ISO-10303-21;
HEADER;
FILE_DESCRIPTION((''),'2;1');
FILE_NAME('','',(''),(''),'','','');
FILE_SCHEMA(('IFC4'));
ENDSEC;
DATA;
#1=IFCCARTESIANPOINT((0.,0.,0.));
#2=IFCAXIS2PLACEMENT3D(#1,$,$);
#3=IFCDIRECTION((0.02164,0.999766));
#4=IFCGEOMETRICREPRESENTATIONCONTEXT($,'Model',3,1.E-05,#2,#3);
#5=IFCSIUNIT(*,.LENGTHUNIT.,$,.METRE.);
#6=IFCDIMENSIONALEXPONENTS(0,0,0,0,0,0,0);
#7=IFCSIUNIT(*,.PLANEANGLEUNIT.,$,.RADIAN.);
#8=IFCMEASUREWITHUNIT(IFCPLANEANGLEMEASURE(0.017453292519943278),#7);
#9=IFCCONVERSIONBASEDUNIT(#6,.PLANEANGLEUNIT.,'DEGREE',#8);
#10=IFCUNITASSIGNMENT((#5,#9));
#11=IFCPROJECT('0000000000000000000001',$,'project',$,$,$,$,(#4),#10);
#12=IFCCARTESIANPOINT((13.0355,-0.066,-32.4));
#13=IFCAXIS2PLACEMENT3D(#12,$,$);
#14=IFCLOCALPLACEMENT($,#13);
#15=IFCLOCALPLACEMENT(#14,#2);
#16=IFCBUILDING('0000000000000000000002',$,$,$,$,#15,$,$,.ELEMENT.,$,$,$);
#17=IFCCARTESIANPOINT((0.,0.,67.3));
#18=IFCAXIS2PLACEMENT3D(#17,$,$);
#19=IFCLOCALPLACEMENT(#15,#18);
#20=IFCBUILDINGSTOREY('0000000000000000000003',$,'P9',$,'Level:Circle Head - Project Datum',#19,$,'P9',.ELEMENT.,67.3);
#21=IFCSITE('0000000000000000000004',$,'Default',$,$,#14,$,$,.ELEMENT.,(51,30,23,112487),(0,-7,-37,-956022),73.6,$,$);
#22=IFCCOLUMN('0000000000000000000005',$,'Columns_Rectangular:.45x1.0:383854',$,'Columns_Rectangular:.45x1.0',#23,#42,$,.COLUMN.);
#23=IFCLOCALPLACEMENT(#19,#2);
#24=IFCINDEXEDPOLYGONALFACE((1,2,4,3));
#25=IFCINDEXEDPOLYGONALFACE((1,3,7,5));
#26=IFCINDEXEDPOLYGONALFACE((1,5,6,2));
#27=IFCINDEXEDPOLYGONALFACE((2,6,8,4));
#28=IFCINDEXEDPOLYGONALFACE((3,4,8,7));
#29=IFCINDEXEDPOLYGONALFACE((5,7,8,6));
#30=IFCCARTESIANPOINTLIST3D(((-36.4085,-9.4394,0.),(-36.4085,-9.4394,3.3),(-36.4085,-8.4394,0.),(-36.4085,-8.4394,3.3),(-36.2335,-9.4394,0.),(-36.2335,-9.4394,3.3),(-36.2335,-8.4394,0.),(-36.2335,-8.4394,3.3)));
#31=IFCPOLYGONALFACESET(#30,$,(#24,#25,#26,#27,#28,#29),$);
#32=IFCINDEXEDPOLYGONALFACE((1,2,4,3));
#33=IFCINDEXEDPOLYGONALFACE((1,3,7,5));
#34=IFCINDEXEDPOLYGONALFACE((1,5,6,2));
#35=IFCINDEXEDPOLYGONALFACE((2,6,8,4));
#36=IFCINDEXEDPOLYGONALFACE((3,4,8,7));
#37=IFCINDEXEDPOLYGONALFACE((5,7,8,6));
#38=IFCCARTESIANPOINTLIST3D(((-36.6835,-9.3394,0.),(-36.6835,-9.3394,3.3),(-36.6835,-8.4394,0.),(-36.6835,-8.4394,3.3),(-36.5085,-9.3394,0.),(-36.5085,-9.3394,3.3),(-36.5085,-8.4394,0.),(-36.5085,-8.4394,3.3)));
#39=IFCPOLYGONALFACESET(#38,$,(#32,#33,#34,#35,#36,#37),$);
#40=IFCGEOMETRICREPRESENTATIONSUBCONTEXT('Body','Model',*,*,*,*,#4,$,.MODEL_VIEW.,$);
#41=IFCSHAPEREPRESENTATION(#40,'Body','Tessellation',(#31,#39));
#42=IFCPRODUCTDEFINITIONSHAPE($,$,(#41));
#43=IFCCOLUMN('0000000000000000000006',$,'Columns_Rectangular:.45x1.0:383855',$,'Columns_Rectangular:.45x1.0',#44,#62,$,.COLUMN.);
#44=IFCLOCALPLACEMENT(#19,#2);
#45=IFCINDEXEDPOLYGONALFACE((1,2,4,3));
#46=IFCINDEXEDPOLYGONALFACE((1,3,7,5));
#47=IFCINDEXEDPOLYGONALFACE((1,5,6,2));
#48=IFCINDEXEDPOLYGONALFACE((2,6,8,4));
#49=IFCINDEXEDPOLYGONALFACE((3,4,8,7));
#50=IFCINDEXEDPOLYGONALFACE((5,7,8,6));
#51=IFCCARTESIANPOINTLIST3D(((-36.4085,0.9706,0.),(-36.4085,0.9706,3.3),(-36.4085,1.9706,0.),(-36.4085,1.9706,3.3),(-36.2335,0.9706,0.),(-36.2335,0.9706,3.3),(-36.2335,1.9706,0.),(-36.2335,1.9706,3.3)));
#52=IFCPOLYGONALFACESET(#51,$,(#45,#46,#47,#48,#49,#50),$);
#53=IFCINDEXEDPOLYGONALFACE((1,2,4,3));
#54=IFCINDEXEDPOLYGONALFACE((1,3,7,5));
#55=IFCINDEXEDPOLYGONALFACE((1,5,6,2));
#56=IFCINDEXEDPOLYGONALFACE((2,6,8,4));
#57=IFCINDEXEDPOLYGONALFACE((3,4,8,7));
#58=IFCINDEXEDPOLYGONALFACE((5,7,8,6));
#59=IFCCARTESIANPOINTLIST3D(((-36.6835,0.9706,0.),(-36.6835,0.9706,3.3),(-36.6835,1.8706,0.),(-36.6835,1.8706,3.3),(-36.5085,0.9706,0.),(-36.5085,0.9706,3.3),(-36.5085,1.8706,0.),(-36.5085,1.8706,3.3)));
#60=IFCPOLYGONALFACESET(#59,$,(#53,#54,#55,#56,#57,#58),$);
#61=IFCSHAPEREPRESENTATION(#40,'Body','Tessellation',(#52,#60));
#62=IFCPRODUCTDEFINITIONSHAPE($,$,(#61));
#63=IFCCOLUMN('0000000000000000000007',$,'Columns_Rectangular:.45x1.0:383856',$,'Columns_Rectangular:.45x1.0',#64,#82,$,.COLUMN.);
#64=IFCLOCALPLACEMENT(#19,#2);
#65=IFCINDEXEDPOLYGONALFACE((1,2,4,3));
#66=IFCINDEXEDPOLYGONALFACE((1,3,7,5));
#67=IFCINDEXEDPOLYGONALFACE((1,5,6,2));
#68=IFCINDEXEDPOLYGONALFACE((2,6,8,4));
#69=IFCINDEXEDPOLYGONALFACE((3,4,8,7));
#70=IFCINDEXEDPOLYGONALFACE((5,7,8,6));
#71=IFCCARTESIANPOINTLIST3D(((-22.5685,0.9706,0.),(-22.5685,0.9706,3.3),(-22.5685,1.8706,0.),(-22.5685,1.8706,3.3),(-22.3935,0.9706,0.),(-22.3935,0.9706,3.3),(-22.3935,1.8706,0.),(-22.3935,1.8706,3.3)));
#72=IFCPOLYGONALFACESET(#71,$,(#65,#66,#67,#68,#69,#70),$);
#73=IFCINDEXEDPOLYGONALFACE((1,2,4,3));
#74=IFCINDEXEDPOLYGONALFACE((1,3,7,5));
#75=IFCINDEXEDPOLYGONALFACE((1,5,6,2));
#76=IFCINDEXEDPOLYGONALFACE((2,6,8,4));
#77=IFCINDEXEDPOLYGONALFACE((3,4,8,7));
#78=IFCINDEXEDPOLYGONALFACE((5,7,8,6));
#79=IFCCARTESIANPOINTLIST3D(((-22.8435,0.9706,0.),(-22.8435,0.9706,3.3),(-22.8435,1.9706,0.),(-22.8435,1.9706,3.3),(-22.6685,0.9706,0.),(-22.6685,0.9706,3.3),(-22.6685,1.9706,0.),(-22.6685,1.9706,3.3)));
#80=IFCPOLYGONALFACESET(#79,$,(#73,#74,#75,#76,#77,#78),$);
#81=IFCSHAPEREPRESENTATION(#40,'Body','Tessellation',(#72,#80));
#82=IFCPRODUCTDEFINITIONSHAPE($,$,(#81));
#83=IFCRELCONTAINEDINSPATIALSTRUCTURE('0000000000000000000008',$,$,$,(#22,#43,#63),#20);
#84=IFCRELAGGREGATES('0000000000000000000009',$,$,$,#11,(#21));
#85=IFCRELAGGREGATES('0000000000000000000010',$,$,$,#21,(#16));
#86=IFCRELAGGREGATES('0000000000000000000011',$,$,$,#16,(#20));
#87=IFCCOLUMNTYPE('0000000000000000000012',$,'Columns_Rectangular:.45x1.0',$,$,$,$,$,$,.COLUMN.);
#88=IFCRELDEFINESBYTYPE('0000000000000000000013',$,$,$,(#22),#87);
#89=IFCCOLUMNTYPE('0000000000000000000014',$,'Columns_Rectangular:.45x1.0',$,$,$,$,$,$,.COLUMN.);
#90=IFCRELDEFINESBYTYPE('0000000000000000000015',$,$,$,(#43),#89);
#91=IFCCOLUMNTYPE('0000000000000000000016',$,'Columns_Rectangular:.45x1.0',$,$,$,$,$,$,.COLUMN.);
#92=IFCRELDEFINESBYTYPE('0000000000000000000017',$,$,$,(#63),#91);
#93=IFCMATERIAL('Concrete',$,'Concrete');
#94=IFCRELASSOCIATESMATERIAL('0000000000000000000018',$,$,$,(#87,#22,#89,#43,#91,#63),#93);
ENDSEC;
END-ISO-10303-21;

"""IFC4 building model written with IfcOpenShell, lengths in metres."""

from ifc_helpers import new_model, entity, si_unit, converted_unit, direction, frame, origin, place, context, subcontext, project, spatial, indexed_curve, outline, extrude, source, transform, mapped, material, type_object, type_shapes, element, save


model = new_model("IFC4")

# Units and contexts
model_context = context("Model", 3, precision=1e-05, world=origin(), true_north=direction((0.02164, 0.999766)))
body_context = subcontext(model_context, "Body", "Model", "MODEL_VIEW")
ifc_project = project(units=[si_unit("LENGTHUNIT", "METRE"), converted_unit("PLANEANGLEUNIT", "DEGREE", entity("IfcPlaneAngleMeasure", 0.017453292519943278), si_unit("PLANEANGLEUNIT", "RADIAN"), dimensions=[0, 0, 0, 0, 0, 0, 0])], contexts=[model_context])

# Site, building, storey
site_placement = place(None, frame((13.0355, -0.066, -32.4)))
site = spatial("IfcSite", under=ifc_project, at=site_placement, Name="Default", CompositionType="ELEMENT", RefLatitude=(51, 30, 23, 112487), RefLongitude=(0, -7, -37, -956022), RefElevation=73.6)
building_placement = place(site_placement, origin())
building = spatial("IfcBuilding", under=site, at=building_placement, CompositionType="ELEMENT")
storey_placement = place(building_placement, frame((0.0, 0.0, 67.3)))
storey = spatial("IfcBuildingStorey", under=building, at=storey_placement, Name="P9", ObjectType="Level:Circle Head - Project Datum", LongName="P9", CompositionType="ELEMENT", Elevation=67.3)

# Columns
ifc_material = material(Name="Concrete", Category="Concrete")
column_type_1 = type_object("IfcColumnType", Name="Columns_Rectangular:.45x1.0", PredefinedType="COLUMN", material=ifc_material)
shared_shape_1 = source(origin(), body_context, "Body", "SweptSolid", [
    extrude(outline(indexed_curve([(-0.0875, -0.5), (0.0875, -0.5), (0.0875, 0.5), (-0.0875, 0.5), (-0.0875, -0.5)], self_intersect=False)), frame((-36.321, -8.9394, 67.3), z_axis=(0.0, 0.0, 1.0), x_axis=(-1.0, 0.0, 0.0)), (0.0, 0.0, 1.0), 3.3),
    extrude(outline(indexed_curve([(-0.45, -0.0875), (0.45, -0.0875), (0.45, 0.0875), (-0.45, 0.0875), (-0.45, -0.0875)], self_intersect=False)), frame((-36.596, -8.8894, 67.3), z_axis=(0.0, 0.0, 1.0), x_axis=(0.0, -1.0, 0.0)), (0.0, 0.0, 1.0), 3.3),
])
type_shapes(column_type_1, [shared_shape_1])
column_1_placement = place(storey_placement, frame((0.0, 0.0, -67.3)))
element("IfcColumn", 1, at=column_1_placement, inside=storey, type_object=column_type_1, material=ifc_material, Name="Columns_Rectangular:.45x1.0:383854", ObjectType="Columns_Rectangular:.45x1.0", PredefinedType="COLUMN", context=body_context, shape_type="MappedRepresentation", body=[
    mapped(shared_shape_1, transform((0.0, 0.0, 0.0), scale=1.0)),
])
column_type_2 = type_object("IfcColumnType", Name="Columns_Rectangular:.45x1.0", PredefinedType="COLUMN", material=ifc_material)
shared_shape_2 = source(origin(), body_context, "Body", "SweptSolid", [
    extrude(outline(indexed_curve([(-0.0875, -0.5), (0.0875, -0.5), (0.0875, 0.5), (-0.0875, 0.5), (-0.0875, -0.5)], self_intersect=False)), frame((-36.321, 1.4706, 67.3), z_axis=(0.0, 0.0, 1.0), x_axis=(-1.0, 0.0, 0.0)), (0.0, 0.0, 1.0), 3.3),
    extrude(outline(indexed_curve([(-0.45, -0.0875), (0.45, -0.0875), (0.45, 0.0875), (-0.45, 0.0875), (-0.45, -0.0875)], self_intersect=False)), frame((-36.596, 1.4206, 67.3), z_axis=(0.0, 0.0, 1.0), x_axis=(0.0, 1.0, 0.0)), (0.0, 0.0, 1.0), 3.3),
])
type_shapes(column_type_2, [shared_shape_2])
column_2_placement = place(storey_placement, frame((0.0, 0.0, -67.3)))
element("IfcColumn", 2, at=column_2_placement, inside=storey, type_object=column_type_2, material=ifc_material, Name="Columns_Rectangular:.45x1.0:383855", ObjectType="Columns_Rectangular:.45x1.0", PredefinedType="COLUMN", context=body_context, shape_type="MappedRepresentation", body=[
    mapped(shared_shape_2, transform((0.0, 0.0, 0.0), scale=1.0)),
])
column_type_3 = type_object("IfcColumnType", Name="Columns_Rectangular:.45x1.0", PredefinedType="COLUMN", material=ifc_material)
shared_shape_3 = source(origin(), body_context, "Body", "SweptSolid", [
    extrude(outline(indexed_curve([(-0.45, -0.0875), (0.45, -0.0875), (0.45, 0.0875), (-0.45, 0.0875), (-0.45, -0.0875)], self_intersect=False)), frame((-22.481, 1.4206, 67.3), z_axis=(0.0, 0.0, 1.0), x_axis=(0.0, 1.0, 0.0)), (0.0, 0.0, 1.0), 3.3),
    extrude(outline(indexed_curve([(-0.0875, -0.5), (0.0875, -0.5), (0.0875, 0.5), (-0.0875, 0.5), (-0.0875, -0.5)], self_intersect=False)), frame((-22.756, 1.4706, 67.3)), (0.0, 0.0, 1.0), 3.3),
])
type_shapes(column_type_3, [shared_shape_3])
column_3_placement = place(storey_placement, frame((0.0, 0.0, -67.3)))
element("IfcColumn", 3, at=column_3_placement, inside=storey, type_object=column_type_3, material=ifc_material, Name="Columns_Rectangular:.45x1.0:383856", ObjectType="Columns_Rectangular:.45x1.0", PredefinedType="COLUMN", context=body_context, shape_type="MappedRepresentation", body=[
    mapped(shared_shape_3, transform((0.0, 0.0, 0.0), scale=1.0)),
])

save(model, "model.ifc")
